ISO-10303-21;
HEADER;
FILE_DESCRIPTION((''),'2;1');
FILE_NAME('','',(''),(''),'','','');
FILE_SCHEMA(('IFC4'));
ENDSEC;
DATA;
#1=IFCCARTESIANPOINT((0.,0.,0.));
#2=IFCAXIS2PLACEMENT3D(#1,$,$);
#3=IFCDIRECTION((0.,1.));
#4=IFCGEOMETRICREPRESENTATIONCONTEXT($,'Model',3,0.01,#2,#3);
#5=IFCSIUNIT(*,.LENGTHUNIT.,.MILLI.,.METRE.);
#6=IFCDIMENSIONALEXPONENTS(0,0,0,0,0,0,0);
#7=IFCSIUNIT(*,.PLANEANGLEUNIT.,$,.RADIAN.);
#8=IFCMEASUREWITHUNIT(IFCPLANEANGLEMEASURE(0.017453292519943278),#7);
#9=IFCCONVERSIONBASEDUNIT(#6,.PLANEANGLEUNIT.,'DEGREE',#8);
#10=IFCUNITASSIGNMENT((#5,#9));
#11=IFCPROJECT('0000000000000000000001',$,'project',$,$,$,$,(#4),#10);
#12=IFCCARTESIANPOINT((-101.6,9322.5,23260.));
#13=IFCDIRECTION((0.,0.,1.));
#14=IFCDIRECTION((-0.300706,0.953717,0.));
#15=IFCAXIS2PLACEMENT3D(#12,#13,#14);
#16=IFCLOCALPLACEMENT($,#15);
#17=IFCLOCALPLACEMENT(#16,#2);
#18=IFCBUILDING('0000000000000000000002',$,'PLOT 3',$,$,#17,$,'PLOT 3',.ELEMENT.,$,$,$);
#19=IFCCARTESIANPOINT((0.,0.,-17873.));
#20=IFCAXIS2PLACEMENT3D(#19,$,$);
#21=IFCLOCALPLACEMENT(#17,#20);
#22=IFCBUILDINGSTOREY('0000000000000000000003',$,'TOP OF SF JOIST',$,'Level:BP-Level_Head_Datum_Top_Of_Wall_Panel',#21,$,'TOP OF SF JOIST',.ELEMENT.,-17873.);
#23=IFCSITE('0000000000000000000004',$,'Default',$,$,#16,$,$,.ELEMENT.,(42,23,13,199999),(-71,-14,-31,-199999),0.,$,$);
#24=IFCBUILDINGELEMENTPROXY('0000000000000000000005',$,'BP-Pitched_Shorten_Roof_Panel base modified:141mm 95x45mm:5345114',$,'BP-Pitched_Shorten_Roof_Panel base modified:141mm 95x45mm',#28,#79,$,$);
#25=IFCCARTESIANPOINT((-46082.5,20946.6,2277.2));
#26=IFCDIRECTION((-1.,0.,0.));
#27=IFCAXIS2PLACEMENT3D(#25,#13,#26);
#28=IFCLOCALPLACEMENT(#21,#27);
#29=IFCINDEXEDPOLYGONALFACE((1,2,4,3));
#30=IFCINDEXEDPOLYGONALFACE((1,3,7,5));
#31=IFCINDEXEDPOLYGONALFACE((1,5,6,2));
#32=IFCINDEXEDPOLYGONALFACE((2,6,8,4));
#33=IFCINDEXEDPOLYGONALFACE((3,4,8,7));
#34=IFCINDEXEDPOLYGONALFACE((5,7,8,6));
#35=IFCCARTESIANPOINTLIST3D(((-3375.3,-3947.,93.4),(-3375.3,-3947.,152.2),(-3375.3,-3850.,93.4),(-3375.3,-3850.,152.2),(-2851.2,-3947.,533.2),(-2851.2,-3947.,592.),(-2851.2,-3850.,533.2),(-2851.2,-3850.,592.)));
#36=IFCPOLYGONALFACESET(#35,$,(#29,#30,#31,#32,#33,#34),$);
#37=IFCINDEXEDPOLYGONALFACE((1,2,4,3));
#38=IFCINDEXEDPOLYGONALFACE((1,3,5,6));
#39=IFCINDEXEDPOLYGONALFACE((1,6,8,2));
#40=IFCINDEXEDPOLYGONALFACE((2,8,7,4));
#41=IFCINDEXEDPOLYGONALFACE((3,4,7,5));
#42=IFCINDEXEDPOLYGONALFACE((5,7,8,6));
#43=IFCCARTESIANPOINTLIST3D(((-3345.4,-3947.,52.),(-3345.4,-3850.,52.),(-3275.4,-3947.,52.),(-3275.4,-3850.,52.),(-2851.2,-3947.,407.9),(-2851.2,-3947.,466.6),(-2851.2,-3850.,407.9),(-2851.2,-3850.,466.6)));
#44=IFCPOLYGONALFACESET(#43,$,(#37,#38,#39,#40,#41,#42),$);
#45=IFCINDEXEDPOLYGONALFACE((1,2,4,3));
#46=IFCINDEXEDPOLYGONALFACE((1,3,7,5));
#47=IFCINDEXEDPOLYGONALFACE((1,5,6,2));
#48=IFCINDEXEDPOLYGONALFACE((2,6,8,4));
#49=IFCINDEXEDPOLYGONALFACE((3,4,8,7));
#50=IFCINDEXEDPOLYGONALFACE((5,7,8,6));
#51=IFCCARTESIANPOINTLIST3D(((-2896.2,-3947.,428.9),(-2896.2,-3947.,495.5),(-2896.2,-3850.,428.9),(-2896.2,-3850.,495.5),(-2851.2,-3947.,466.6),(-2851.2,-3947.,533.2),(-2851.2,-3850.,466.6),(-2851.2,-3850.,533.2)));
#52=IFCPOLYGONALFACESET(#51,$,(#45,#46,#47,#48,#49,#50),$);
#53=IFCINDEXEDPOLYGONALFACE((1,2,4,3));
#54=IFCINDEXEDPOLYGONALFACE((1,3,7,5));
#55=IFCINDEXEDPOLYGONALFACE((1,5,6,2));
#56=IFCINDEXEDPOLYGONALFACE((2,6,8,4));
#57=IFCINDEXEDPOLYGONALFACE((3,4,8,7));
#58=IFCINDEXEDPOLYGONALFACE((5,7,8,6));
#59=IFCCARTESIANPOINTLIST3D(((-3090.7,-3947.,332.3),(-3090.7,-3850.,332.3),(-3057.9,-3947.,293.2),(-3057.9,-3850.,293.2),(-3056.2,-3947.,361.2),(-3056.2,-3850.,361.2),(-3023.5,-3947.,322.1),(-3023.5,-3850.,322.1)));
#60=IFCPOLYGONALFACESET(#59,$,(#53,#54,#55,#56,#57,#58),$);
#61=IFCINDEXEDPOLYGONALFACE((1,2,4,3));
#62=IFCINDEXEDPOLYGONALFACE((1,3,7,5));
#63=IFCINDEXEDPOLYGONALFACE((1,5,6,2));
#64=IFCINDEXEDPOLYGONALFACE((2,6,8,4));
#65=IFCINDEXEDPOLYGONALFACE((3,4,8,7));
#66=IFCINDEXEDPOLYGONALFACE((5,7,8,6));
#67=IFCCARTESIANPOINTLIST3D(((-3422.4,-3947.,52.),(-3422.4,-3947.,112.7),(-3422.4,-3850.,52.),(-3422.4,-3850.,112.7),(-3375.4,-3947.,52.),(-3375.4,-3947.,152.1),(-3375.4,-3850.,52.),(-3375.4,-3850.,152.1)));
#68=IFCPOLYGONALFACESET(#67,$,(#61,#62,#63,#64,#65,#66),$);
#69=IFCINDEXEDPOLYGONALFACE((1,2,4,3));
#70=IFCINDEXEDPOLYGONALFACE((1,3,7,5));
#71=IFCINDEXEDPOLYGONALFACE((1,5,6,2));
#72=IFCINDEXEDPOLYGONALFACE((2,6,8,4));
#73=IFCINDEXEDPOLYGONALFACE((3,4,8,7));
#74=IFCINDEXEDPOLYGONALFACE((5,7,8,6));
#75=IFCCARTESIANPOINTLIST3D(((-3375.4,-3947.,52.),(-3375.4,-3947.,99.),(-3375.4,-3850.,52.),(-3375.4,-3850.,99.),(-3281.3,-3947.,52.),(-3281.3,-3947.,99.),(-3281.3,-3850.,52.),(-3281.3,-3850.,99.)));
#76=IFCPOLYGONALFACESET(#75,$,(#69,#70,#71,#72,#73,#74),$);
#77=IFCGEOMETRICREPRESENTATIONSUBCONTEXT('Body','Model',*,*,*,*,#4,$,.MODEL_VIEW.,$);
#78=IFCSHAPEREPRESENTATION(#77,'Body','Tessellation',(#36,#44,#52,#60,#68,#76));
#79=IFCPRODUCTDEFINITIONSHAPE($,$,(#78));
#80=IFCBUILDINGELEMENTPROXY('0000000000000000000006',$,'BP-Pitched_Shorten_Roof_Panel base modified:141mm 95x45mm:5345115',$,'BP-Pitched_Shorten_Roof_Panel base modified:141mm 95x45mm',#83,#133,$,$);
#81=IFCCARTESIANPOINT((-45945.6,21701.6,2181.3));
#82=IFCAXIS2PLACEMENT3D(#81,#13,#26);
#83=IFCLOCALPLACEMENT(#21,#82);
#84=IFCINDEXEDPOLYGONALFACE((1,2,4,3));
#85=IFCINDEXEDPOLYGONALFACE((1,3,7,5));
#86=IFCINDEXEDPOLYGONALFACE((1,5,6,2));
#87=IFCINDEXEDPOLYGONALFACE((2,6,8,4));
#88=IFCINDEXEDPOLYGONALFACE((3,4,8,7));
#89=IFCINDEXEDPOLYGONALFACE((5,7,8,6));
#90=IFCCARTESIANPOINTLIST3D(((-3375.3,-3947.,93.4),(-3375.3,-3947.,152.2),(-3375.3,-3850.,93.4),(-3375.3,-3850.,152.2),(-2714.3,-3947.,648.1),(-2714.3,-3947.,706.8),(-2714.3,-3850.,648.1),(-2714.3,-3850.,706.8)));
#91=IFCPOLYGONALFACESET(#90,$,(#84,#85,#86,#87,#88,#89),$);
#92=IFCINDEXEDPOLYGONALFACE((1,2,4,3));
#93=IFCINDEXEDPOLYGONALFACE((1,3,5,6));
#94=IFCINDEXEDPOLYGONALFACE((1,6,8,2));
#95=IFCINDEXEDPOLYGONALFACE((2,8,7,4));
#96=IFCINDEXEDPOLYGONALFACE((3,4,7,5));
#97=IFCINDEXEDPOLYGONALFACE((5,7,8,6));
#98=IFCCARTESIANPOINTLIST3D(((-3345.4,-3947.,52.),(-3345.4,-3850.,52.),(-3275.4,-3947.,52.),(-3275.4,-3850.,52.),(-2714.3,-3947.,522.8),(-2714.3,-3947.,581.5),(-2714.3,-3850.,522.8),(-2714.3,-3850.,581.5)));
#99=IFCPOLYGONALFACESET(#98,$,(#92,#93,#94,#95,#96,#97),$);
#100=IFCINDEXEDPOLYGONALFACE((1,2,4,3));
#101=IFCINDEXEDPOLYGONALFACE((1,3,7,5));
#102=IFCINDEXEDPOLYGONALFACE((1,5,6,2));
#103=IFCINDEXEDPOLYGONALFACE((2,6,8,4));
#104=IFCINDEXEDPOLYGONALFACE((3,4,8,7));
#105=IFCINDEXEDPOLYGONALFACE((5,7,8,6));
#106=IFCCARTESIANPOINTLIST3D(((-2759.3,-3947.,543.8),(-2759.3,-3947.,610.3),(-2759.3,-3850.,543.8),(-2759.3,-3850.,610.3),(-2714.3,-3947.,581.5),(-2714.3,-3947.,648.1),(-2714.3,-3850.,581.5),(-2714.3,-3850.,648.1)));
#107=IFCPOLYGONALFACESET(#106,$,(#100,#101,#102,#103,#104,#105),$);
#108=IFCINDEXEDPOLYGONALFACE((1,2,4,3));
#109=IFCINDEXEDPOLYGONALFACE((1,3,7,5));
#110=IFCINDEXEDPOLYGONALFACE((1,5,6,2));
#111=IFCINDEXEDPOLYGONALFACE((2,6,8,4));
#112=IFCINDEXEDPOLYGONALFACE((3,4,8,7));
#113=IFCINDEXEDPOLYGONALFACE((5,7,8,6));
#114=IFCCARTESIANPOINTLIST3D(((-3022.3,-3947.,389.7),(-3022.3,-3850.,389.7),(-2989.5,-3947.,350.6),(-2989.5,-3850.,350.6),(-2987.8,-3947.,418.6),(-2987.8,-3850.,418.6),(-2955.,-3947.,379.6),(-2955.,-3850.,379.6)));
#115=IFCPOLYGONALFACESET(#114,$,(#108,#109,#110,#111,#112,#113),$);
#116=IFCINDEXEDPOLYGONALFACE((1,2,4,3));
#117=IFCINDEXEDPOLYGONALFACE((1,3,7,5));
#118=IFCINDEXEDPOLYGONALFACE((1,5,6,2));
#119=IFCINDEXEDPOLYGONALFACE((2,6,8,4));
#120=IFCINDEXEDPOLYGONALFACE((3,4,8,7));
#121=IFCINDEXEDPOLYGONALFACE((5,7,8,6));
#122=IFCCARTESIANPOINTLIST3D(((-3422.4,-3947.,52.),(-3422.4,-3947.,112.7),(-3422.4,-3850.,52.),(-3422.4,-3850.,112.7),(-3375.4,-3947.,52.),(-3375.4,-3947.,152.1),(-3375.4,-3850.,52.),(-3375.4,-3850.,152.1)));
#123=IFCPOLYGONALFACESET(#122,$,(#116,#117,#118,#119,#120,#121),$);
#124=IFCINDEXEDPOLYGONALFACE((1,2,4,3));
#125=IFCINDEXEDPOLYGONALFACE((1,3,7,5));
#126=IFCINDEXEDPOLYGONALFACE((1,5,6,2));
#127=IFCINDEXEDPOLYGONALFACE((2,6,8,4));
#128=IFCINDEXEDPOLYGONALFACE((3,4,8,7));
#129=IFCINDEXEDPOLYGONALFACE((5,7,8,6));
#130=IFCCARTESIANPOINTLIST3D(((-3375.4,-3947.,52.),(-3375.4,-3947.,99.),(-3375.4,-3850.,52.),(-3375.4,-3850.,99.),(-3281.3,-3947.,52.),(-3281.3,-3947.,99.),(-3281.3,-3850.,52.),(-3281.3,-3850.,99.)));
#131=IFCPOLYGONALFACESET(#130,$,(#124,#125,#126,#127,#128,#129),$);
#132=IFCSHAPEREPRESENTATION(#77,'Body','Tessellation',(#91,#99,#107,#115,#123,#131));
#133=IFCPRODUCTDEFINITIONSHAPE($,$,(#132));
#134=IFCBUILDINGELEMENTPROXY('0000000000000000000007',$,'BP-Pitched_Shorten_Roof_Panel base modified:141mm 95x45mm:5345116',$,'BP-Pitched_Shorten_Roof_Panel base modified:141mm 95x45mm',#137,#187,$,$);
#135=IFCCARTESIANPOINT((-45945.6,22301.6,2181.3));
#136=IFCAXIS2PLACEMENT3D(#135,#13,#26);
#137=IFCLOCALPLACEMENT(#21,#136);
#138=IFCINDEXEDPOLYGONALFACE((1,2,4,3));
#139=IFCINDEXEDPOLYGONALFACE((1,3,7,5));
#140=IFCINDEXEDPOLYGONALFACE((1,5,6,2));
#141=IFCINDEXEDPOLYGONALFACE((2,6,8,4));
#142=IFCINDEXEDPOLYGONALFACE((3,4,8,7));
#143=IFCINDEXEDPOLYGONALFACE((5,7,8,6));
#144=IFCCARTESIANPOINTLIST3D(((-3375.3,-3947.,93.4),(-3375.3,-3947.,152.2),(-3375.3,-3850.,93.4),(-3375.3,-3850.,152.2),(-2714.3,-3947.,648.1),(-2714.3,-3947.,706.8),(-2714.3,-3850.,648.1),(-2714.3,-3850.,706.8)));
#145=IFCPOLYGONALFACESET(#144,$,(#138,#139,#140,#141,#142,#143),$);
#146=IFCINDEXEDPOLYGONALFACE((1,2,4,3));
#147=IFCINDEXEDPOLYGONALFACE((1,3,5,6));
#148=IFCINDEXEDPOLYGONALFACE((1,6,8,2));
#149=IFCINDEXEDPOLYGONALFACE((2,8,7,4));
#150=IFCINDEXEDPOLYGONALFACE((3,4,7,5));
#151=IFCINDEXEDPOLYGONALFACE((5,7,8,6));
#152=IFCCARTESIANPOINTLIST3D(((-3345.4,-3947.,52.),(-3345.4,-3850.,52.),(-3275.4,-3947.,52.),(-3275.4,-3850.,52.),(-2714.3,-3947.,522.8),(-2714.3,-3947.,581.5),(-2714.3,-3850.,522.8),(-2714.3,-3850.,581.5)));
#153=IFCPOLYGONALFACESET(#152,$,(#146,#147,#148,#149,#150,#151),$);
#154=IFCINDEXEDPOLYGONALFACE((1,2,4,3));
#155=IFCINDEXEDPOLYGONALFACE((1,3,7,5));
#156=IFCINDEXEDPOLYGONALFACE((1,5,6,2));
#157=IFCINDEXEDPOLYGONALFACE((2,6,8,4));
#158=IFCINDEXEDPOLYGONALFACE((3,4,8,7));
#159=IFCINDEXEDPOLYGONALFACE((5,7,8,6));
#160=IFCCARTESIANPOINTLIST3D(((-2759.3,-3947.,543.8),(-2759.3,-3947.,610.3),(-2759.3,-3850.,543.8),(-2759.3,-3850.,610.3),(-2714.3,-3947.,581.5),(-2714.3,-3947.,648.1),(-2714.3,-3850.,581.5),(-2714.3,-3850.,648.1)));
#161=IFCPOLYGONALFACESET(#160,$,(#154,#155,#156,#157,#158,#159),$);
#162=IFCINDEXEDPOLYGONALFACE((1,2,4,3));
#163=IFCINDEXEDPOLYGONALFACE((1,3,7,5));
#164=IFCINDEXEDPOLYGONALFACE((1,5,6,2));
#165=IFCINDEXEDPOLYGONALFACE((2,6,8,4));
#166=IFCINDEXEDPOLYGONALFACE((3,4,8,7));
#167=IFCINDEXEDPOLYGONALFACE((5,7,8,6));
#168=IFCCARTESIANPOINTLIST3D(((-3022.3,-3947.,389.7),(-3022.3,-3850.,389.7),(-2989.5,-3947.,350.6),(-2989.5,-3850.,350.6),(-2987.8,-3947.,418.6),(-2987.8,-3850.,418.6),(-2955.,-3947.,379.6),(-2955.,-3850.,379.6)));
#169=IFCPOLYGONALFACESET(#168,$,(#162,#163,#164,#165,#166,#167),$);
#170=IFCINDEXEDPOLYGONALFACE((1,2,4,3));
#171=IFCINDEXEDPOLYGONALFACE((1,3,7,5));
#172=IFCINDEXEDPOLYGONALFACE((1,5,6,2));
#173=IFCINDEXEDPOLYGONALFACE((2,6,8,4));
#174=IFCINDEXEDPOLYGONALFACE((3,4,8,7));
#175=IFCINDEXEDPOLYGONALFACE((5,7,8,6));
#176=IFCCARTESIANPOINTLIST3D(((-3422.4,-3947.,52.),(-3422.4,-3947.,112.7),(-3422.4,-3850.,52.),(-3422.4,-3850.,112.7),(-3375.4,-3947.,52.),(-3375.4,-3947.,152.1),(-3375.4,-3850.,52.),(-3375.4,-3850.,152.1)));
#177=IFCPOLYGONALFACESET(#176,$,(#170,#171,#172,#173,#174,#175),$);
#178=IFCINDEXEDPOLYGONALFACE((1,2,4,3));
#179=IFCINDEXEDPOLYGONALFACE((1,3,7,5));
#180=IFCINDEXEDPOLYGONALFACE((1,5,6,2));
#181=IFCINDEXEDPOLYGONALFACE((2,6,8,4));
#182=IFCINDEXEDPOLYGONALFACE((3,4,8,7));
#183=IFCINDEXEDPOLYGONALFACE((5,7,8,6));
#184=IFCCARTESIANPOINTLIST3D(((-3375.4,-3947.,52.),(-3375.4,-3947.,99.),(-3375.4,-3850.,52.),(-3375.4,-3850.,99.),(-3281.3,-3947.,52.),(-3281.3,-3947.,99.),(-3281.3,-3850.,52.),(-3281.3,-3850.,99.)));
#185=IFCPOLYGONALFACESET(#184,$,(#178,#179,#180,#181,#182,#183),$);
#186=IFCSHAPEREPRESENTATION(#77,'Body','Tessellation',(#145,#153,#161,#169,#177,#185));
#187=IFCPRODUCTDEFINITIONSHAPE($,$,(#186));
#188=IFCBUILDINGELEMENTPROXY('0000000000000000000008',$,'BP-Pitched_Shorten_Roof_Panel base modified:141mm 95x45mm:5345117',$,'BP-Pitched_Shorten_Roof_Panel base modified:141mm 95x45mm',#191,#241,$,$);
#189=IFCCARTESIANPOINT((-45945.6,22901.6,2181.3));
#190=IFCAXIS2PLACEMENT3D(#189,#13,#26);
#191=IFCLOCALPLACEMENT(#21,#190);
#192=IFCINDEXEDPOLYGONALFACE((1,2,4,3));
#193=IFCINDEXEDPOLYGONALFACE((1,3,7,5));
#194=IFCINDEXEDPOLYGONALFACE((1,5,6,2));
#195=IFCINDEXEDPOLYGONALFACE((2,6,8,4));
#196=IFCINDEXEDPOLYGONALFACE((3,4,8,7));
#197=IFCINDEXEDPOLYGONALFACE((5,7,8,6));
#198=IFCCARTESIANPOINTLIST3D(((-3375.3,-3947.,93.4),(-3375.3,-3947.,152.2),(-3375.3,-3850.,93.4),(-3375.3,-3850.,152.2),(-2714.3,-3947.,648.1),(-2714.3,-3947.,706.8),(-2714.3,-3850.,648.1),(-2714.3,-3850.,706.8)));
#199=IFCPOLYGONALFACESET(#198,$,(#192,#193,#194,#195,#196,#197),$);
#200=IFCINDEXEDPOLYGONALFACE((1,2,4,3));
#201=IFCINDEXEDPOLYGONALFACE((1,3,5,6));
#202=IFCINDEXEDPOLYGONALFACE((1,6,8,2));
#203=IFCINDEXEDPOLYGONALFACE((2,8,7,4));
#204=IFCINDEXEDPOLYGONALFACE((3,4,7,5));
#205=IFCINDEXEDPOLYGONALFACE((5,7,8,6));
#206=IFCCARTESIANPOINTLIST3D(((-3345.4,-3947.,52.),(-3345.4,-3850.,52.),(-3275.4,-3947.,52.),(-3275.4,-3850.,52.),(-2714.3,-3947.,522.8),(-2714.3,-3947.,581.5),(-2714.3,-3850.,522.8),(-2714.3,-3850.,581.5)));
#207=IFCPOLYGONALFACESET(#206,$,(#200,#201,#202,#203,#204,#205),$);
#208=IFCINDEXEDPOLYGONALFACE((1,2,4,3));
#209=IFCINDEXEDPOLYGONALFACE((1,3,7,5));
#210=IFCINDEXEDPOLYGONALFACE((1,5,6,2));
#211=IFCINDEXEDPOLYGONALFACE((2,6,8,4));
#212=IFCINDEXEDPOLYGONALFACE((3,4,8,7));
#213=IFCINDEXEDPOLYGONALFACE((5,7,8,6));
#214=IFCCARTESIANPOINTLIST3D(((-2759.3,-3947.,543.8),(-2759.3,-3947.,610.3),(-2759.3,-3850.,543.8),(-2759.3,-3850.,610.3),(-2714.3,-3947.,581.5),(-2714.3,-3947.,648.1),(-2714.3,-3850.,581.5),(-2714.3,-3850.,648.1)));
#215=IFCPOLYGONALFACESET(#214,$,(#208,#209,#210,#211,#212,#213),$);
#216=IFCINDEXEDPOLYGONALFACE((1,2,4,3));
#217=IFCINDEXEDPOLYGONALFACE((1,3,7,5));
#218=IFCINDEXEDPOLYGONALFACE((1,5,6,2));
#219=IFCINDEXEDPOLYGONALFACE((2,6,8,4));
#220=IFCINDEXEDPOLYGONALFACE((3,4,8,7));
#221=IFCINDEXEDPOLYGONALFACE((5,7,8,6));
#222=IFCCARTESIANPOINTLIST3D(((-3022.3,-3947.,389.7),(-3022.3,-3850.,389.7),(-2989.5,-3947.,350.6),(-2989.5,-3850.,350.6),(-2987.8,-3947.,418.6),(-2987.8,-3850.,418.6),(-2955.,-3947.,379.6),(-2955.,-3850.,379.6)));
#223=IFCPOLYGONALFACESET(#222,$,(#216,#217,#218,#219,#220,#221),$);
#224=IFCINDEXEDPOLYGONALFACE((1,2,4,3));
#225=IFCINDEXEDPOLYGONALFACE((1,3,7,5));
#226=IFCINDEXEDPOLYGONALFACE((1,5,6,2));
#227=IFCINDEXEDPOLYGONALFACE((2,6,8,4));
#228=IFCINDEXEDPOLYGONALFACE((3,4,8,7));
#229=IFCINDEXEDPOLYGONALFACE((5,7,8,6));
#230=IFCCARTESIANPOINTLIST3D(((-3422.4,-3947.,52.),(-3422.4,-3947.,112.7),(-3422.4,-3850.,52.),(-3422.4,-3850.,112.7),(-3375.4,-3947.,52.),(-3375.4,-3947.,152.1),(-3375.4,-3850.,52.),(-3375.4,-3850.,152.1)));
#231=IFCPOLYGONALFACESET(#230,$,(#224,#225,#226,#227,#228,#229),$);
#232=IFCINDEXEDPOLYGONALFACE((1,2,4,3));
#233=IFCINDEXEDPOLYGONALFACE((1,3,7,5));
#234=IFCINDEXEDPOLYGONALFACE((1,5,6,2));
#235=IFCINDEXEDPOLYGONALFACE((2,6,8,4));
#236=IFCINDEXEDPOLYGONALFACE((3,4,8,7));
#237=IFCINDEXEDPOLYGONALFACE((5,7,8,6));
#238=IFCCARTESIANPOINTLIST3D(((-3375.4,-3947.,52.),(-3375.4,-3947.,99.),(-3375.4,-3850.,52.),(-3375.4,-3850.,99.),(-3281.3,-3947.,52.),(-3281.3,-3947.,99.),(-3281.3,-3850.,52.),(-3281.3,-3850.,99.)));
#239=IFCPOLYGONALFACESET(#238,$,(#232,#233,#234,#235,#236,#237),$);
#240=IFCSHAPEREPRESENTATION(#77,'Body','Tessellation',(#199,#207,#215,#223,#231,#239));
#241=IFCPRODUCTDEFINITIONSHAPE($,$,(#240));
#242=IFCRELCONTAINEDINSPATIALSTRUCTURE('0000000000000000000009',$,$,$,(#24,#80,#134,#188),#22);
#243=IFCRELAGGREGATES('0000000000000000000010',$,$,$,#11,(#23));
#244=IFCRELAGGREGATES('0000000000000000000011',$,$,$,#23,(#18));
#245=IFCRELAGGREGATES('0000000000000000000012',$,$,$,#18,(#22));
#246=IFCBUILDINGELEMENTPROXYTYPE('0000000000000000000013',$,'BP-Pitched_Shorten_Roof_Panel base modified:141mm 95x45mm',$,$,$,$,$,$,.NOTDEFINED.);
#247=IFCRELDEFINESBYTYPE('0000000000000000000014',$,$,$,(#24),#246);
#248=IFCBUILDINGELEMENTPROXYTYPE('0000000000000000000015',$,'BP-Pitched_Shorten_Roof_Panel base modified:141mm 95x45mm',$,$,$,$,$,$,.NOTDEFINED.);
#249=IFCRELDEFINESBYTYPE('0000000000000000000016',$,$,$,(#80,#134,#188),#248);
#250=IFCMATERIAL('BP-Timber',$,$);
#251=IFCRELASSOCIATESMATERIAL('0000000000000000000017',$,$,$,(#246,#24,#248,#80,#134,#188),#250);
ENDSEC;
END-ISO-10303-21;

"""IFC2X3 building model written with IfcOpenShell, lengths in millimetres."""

from ifc_helpers import new_model, entity, si_unit, converted_unit, direction, frame, frame_2d, origin, place, context, subcontext, project, spatial, polyline, rectangle, outline, extrude, source, transform, mapped, material, type_object, type_shapes, element, save


model = new_model("IFC2X3")

# Units and contexts
model_context = context("Model", 3, precision=0.01, world=origin(), true_north=direction((0.0, 1.0)))
body_context = subcontext(model_context, "Body", "Model", "MODEL_VIEW")
ifc_project = project(units=[si_unit("LENGTHUNIT", "METRE", prefix="MILLI"), converted_unit("PLANEANGLEUNIT", "DEGREE", entity("IfcPlaneAngleMeasure", 0.017453292519943278), si_unit("PLANEANGLEUNIT", "RADIAN"), dimensions=[0, 0, 0, 0, 0, 0, 0])], contexts=[model_context])

# Site, building, storey
site_placement = place(None, frame((-101.6, 9322.5, 23260.0), z_axis=(0.0, 0.0, 1.0), x_axis=(-0.300706, 0.953717, 0.0)))
site = spatial("IfcSite", under=ifc_project, at=site_placement, Name="Default", CompositionType="ELEMENT", RefLatitude=(42, 23, 13, 199999), RefLongitude=(-71, -14, -31, -199999), RefElevation=0.0)
building_placement = place(site_placement, origin())
building = spatial("IfcBuilding", under=site, at=building_placement, Name="PLOT 3", LongName="PLOT 3", CompositionType="ELEMENT")
storey_placement = place(building_placement, frame((0.0, 0.0, -17873.0)))
storey = spatial("IfcBuildingStorey", under=building, at=storey_placement, Name="TOP OF SF JOIST", ObjectType="Level:BP-Level_Head_Datum_Top_Of_Wall_Panel", LongName="TOP OF SF JOIST", CompositionType="ELEMENT", Elevation=-17873.0)

# Building element proxies
ifc_material_1 = material(Name="BP-Timber")
building_element_proxy_type_1 = type_object("IfcBuildingElementProxyType", Name="BP-Pitched_Shorten_Roof_Panel base modified:141mm 95x45mm", PredefinedType="NOTDEFINED", material=ifc_material_1)
shared_shape_1 = source(origin(), body_context, "Body", "SweptSolid", [
    extrude(outline(polyline([(-249.3, -262.0), (-190.5, -262.0), (249.3, 262.0), (190.5, 262.0), (-249.3, -262.0)])), frame((-3113.3, -3947.0, 342.7), z_axis=(0.0, 1.0, 0.0), x_axis=(0.0, 0.0, -1.0)), (0.0, 0.0, 1.0), 97.0),
    extrude(outline(polyline([(-222.0, -229.6), (-163.3, -229.6), (192.6, 194.6), (192.6, 264.6), (-222.0, -229.6)])), frame((-3080.8, -3947.0, 244.6), z_axis=(0.0, 1.0, 0.0), x_axis=(0.0, 0.0, -1.0)), (0.0, 0.0, 1.0), 97.0),
    extrude(outline(polyline([(-8.0, -25.5), (50.8, -25.5), (8.0, 25.5), (-50.8, 25.5), (-8.0, -25.5)])), frame((-2873.7, -3947.0, 481.0), z_axis=(0.0, 1.0, 0.0), x_axis=(0.766044, 0.0, 0.642788)), (0.0, 0.0, 1.0), 97.0),
    extrude(rectangle(XDim=51.0, YDim=45.0, at=frame_2d((0.0, 0.0), x_axis=(1.0, 0.0))), frame((-3057.1, -3947.0, 327.2), z_axis=(0.0, 1.0, 0.0), x_axis=(0.642788, 0.0, -0.766044)), (0.0, 0.0, 1.0), 97.0),
    extrude(outline(polyline([(-59.9, -23.5), (40.2, -23.5), (40.2, 23.5), (-20.5, 23.5), (-59.9, -23.5)])), frame((-3398.9, -3947.0, 92.2), z_axis=(0.0, 1.0, 0.0), x_axis=(0.0, 0.0, -1.0)), (0.0, 0.0, 1.0), 97.0),
    extrude(rectangle(XDim=94.1, YDim=97.0, at=frame_2d((0.0, 0.0), x_axis=(1.0, 0.0))), frame((-3328.4, -3898.5, 52.0), z_axis=(0.0, 0.0, 1.0), x_axis=(-1.0, 0.0, 0.0)), (0.0, 0.0, 1.0), 47.0),
])
type_shapes(building_element_proxy_type_1, [shared_shape_1])
proxy_1_placement = place(storey_placement, frame((-46082.5, 20946.6, 2277.2), z_axis=(0.0, 0.0, 1.0), x_axis=(-1.0, 0.0, 0.0)))
element("IfcBuildingElementProxy", 1, at=proxy_1_placement, inside=storey, type_object=building_element_proxy_type_1, material=ifc_material_1, Name="BP-Pitched_Shorten_Roof_Panel base modified:141mm 95x45mm:5345114", ObjectType="BP-Pitched_Shorten_Roof_Panel base modified:141mm 95x45mm", context=body_context, shape_type="MappedRepresentation", body=[
    mapped(shared_shape_1, transform((0.0, 0.0, 0.0), scale=1.0)),
])
building_element_proxy_type_2 = type_object("IfcBuildingElementProxyType", Name="BP-Pitched_Shorten_Roof_Panel base modified:141mm 95x45mm", PredefinedType="NOTDEFINED", material=ifc_material_1)
shared_shape_2 = source(origin(), body_context, "Body", "SweptSolid", [
    extrude(outline(polyline([(-306.7, -330.5), (-248.0, -330.5), (306.7, 330.5), (248.0, 330.5), (-306.7, -330.5)])), frame((-3044.8, -3947.0, 400.1), z_axis=(0.0, 1.0, 0.0), x_axis=(0.0, 0.0, -1.0)), (0.0, 0.0, 1.0), 97.0),
    extrude(outline(polyline([(-279.4, -298.0), (-220.7, -298.0), (250.1, 263.0), (250.1, 333.0), (-279.4, -298.0)])), frame((-3012.4, -3947.0, 302.1), z_axis=(0.0, 1.0, 0.0), x_axis=(0.0, 0.0, -1.0)), (0.0, 0.0, 1.0), 97.0),
    extrude(outline(polyline([(-8.0, -25.5), (50.8, -25.5), (8.0, 25.5), (-50.8, 25.5), (-8.0, -25.5)])), frame((-2736.8, -3947.0, 595.9), z_axis=(0.0, 1.0, 0.0), x_axis=(0.766044, 0.0, 0.642788)), (0.0, 0.0, 1.0), 97.0),
    extrude(rectangle(XDim=51.0, YDim=45.0, at=frame_2d((0.0, 0.0), x_axis=(1.0, 0.0))), frame((-2988.6, -3947.0, 384.6), z_axis=(0.0, 1.0, 0.0), x_axis=(0.642788, 0.0, -0.766044)), (0.0, 0.0, 1.0), 97.0),
    extrude(outline(polyline([(-59.9, -23.5), (40.2, -23.5), (40.2, 23.5), (-20.5, 23.5), (-59.9, -23.5)])), frame((-3398.9, -3947.0, 92.2), z_axis=(0.0, 1.0, 0.0), x_axis=(0.0, 0.0, -1.0)), (0.0, 0.0, 1.0), 97.0),
    extrude(rectangle(XDim=94.1, YDim=97.0, at=frame_2d((0.0, 0.0), x_axis=(1.0, 0.0))), frame((-3328.4, -3898.5, 52.0), z_axis=(0.0, 0.0, 1.0), x_axis=(-1.0, 0.0, 0.0)), (0.0, 0.0, 1.0), 47.0),
])
type_shapes(building_element_proxy_type_2, [shared_shape_2])
for number, where, z_axis, x_axis, name in (
    (2, (-45945.6, 21701.6, 2181.3), (0.0, 0.0, 1.0), (-1.0, 0.0, 0.0), "BP-Pitched_Shorten_Roof_Panel base modified:141mm 95x45mm:5345115"),
    (3, (-45945.6, 22301.6, 2181.3), (0.0, 0.0, 1.0), (-1.0, 0.0, 0.0), "BP-Pitched_Shorten_Roof_Panel base modified:141mm 95x45mm:5345116"),
    (4, (-45945.6, 22901.6, 2181.3), (0.0, 0.0, 1.0), (-1.0, 0.0, 0.0), "BP-Pitched_Shorten_Roof_Panel base modified:141mm 95x45mm:5345117"),
):
    element("IfcBuildingElementProxy", number, at=place(storey_placement, frame(where, z_axis=z_axis, x_axis=x_axis)), inside=storey, type_object=building_element_proxy_type_2, material=ifc_material_1, Name=name, ObjectType="BP-Pitched_Shorten_Roof_Panel base modified:141mm 95x45mm", context=body_context, shape_type="MappedRepresentation", body=[
        mapped(shared_shape_2, transform((0.0, 0.0, 0.0), scale=1.0)),
    ])

save(model, "model.ifc")
